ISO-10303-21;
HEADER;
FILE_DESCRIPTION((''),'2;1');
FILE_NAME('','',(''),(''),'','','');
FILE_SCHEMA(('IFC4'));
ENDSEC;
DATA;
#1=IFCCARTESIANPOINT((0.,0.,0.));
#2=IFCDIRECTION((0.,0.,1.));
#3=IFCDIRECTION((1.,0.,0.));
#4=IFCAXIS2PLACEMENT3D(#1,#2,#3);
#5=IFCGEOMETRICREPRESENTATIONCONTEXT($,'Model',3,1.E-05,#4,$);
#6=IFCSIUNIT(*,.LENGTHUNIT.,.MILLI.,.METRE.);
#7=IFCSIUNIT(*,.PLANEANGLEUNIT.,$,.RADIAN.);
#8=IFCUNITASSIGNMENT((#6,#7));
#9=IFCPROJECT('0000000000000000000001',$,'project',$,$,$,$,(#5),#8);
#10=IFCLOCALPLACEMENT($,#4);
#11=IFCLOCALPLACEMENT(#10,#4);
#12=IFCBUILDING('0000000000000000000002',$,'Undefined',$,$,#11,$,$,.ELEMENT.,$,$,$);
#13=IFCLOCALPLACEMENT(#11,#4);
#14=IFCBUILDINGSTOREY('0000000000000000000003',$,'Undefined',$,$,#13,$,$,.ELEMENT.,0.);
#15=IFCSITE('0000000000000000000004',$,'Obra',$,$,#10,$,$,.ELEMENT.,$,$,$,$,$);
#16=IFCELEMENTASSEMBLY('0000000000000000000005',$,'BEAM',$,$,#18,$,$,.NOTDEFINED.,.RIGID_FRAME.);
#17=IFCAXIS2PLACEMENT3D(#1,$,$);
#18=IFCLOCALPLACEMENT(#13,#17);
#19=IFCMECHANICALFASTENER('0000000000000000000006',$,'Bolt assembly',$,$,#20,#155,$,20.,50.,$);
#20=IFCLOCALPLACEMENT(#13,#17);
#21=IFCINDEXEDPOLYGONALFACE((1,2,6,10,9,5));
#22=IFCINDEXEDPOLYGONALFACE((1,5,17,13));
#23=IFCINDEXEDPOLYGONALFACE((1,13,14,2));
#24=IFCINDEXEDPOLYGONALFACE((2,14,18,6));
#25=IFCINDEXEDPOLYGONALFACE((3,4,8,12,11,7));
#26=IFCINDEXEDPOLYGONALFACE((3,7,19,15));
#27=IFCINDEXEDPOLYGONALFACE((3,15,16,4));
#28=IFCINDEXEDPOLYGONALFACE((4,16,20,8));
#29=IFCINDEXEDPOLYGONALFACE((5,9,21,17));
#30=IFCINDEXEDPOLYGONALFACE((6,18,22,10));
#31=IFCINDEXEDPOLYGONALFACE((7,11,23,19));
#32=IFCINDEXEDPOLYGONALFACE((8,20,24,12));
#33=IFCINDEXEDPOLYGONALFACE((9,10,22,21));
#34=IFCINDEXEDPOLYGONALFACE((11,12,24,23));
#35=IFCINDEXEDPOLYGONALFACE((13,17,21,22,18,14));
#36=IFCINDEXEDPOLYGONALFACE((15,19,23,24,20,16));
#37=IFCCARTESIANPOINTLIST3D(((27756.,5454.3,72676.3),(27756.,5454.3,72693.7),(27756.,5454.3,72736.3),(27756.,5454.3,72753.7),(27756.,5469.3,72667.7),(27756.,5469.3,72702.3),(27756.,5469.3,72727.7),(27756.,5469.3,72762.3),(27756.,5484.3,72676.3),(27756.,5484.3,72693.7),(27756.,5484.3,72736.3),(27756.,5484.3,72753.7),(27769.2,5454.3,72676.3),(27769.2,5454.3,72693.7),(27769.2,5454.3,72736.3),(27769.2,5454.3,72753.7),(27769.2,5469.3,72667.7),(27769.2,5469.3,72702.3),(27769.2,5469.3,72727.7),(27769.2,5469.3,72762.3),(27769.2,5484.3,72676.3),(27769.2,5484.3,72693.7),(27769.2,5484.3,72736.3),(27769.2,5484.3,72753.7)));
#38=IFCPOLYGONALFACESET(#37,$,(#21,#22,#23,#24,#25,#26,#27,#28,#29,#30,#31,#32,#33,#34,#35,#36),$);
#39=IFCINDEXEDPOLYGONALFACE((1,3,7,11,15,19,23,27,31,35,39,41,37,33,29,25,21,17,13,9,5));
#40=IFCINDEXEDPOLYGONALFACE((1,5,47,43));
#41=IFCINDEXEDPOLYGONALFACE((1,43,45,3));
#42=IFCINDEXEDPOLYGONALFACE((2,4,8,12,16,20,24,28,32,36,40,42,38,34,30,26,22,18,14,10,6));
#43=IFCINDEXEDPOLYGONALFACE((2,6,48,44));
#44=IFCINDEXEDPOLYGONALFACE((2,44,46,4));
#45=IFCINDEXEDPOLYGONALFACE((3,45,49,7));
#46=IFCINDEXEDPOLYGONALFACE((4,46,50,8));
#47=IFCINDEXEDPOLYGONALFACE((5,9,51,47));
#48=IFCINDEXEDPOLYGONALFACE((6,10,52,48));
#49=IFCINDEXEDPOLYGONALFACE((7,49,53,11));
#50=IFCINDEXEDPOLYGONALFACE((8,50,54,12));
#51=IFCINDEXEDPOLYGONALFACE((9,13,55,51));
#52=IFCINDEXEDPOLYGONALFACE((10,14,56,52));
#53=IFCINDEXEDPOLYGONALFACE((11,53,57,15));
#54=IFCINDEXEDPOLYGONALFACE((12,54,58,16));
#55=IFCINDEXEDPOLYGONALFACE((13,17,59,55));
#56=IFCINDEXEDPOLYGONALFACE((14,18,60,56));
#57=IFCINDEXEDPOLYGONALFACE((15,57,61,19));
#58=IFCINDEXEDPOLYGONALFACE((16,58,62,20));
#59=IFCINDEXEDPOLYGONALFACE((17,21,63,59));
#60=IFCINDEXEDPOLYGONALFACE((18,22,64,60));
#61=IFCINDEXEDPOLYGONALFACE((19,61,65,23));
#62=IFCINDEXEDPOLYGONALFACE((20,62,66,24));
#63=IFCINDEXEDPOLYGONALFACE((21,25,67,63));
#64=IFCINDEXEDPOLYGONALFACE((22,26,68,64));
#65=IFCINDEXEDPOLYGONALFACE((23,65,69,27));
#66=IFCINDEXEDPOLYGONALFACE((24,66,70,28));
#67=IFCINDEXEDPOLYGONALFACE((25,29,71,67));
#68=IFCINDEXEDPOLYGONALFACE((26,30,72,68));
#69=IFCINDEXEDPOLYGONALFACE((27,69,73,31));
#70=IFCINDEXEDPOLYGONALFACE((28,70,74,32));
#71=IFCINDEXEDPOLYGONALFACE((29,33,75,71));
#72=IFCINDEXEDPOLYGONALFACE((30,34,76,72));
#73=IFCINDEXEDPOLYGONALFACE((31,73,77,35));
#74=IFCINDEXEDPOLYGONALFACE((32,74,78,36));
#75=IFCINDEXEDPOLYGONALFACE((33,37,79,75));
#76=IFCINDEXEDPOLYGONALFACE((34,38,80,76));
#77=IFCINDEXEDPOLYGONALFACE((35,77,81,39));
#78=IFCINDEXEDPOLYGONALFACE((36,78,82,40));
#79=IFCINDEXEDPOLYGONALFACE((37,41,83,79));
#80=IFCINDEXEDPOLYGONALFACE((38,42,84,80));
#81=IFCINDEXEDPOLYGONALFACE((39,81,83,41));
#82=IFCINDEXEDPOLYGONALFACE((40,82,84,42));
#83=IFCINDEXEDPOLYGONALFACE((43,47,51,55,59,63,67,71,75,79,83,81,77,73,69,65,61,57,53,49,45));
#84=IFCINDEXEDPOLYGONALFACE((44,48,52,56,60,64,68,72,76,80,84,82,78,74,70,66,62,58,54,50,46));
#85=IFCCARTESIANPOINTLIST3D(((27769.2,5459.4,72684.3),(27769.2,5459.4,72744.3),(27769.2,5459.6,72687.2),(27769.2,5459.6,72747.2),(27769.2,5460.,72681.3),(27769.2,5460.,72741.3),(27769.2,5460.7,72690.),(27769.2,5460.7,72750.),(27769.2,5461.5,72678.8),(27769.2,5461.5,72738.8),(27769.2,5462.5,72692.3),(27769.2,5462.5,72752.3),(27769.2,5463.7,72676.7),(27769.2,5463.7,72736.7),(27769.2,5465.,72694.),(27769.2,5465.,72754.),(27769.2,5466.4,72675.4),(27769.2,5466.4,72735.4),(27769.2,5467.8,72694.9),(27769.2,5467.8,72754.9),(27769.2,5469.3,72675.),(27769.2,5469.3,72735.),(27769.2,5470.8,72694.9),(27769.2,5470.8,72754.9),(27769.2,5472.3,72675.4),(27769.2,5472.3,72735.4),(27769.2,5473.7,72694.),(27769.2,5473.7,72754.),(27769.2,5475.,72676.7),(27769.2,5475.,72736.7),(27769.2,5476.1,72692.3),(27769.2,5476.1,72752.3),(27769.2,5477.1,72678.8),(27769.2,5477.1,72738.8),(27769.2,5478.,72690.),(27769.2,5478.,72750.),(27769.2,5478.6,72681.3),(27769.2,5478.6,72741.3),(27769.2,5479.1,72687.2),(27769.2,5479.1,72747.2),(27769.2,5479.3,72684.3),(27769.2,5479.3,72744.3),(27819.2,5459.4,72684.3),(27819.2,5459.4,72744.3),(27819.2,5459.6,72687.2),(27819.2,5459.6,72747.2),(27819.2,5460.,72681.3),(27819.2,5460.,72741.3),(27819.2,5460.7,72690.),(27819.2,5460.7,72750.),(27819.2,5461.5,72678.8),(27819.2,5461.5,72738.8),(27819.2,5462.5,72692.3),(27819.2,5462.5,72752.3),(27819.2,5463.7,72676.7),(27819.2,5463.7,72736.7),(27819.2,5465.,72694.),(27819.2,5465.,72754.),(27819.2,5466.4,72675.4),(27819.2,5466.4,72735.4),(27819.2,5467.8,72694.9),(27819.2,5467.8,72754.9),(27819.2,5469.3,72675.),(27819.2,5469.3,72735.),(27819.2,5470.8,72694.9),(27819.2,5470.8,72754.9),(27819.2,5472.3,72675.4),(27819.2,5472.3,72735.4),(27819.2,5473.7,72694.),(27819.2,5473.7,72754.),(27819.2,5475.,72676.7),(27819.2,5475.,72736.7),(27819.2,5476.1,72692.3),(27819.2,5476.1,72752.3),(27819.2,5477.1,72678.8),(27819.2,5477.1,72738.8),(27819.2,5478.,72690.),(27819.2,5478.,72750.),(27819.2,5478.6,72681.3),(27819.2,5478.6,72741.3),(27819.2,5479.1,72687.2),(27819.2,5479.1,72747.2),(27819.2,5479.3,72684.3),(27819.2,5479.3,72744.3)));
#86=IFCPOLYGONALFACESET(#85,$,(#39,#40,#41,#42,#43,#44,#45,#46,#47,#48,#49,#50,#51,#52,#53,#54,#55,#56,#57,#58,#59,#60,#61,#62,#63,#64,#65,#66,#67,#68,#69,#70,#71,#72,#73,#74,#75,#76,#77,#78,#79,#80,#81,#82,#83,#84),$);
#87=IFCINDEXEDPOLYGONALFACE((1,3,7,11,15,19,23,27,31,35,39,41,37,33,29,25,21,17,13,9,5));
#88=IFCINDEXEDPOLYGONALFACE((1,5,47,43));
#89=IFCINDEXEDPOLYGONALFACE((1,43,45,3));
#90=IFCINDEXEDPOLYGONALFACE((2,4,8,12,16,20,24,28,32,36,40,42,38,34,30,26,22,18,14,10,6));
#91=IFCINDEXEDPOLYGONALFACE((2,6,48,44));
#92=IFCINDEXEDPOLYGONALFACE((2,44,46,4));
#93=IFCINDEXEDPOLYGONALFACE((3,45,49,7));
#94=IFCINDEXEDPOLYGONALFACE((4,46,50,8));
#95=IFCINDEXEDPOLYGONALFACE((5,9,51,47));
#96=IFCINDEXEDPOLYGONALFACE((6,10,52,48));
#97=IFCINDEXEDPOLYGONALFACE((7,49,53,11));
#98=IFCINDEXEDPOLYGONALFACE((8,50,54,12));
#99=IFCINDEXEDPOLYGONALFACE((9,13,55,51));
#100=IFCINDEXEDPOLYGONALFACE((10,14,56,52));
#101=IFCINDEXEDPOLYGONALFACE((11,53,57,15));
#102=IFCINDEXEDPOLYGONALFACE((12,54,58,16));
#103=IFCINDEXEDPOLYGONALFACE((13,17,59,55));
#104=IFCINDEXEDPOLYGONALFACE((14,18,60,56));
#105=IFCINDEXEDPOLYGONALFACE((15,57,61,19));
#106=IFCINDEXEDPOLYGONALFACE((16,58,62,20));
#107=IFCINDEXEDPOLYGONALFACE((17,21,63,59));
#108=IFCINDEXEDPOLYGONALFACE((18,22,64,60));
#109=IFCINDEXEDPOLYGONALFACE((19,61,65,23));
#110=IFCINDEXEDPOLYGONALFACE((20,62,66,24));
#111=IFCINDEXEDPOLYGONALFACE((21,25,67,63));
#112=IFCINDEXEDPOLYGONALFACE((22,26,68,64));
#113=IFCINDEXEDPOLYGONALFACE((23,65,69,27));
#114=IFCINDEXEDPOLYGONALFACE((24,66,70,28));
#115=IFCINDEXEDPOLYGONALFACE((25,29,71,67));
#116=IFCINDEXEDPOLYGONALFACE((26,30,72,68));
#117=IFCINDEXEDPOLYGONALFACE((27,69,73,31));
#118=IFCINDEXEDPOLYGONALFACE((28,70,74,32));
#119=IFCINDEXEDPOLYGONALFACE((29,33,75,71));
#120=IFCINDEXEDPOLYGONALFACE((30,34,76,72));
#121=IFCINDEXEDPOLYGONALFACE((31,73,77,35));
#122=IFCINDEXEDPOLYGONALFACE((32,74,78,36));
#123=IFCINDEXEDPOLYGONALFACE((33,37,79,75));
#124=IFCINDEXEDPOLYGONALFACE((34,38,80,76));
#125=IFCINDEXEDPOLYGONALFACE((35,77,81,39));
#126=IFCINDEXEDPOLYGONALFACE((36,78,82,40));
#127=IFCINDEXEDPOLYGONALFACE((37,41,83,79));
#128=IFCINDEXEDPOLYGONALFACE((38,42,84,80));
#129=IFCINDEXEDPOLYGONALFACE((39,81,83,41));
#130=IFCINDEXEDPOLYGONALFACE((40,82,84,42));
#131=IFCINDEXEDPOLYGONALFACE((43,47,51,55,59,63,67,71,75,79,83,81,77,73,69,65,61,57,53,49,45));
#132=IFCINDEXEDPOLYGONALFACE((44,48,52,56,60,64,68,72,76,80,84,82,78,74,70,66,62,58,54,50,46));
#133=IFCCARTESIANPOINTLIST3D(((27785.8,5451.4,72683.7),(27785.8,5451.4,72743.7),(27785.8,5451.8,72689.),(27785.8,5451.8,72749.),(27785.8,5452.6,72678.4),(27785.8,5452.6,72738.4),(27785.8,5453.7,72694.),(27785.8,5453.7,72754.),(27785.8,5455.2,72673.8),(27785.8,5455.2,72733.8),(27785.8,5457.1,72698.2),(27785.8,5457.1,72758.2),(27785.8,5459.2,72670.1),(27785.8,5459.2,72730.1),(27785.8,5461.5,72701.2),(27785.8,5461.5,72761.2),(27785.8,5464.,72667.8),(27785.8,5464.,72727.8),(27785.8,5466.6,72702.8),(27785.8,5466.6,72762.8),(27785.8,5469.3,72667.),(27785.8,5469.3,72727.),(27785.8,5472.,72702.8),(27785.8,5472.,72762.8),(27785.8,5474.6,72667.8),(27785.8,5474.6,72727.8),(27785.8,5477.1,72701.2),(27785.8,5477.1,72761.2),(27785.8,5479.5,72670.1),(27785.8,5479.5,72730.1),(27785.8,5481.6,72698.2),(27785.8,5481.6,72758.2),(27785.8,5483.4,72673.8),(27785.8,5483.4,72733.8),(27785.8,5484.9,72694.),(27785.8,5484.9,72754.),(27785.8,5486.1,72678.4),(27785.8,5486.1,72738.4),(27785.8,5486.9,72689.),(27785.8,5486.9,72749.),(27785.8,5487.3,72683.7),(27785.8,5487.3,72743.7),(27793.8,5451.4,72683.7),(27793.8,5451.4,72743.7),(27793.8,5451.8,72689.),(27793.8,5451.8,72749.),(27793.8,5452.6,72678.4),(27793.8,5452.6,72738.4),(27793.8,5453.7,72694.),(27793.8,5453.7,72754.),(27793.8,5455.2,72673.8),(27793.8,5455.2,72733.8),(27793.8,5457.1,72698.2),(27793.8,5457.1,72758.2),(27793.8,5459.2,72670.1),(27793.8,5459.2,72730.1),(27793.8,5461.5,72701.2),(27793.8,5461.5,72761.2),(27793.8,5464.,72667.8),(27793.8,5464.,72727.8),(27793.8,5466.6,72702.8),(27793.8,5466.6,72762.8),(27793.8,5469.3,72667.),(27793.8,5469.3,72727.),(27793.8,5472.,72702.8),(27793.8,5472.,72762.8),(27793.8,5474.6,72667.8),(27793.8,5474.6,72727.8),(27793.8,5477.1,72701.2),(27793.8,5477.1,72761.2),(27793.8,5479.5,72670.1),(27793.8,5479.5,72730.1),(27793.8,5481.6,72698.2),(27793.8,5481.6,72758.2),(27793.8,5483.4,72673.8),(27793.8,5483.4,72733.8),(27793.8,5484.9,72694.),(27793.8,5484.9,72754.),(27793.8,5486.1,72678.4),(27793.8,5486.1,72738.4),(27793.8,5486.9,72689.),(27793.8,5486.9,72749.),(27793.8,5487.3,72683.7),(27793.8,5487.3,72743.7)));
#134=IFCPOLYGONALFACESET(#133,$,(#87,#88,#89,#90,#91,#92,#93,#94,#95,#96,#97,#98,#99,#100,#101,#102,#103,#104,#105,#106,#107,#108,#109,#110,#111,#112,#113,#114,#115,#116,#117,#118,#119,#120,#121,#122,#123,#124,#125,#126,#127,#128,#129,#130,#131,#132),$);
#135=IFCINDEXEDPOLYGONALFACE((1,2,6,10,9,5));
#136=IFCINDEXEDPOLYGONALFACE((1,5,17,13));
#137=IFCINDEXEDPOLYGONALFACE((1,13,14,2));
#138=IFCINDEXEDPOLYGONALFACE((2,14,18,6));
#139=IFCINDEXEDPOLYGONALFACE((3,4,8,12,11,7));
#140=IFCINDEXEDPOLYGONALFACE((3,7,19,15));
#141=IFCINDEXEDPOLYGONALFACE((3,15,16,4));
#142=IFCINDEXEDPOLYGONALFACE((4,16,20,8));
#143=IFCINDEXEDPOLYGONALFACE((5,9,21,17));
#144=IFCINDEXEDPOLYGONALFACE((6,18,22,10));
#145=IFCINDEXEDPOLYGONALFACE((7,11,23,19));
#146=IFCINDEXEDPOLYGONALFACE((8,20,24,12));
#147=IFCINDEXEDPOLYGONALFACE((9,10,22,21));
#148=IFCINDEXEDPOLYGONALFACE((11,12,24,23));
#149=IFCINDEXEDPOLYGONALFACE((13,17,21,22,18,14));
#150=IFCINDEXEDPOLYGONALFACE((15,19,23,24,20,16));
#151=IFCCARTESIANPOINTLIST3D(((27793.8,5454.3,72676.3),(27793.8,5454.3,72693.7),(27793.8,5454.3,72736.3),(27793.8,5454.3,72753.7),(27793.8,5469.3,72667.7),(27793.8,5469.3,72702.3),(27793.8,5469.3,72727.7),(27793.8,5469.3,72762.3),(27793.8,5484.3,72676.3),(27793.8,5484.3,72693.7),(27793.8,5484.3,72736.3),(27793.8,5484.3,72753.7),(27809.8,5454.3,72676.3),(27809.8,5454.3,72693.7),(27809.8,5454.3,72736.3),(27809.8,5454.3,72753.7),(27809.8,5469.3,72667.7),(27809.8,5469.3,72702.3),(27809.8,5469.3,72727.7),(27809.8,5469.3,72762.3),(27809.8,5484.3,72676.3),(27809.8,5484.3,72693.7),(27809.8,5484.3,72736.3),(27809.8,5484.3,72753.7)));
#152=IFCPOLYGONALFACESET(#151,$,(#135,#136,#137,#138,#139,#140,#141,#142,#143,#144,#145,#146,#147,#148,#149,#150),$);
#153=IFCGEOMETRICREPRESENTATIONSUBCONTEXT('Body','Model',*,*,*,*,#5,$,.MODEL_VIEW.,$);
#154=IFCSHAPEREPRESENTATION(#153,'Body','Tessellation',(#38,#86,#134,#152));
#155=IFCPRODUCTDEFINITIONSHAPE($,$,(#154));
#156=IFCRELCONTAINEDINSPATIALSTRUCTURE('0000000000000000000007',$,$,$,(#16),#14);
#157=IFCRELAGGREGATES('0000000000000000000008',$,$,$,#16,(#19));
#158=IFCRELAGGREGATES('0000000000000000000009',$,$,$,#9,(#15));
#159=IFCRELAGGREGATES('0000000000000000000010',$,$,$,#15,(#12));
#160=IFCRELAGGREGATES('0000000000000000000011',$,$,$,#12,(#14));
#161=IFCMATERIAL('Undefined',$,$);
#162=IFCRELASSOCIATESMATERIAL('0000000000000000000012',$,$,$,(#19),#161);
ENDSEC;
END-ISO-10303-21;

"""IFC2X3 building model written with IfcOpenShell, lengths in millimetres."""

from ifc_helpers import new_model, si_unit, frame, origin_with_axes, origin_2d_with_axis, place, context, subcontext, project, spatial, polyline, circle, outline, extrude, source, transform, mapped, material, element, aggregate, save


model = new_model("IFC2X3")

# Units and contexts
model_context = context("Model", 3, precision=1e-05, world=origin_with_axes())
body_context = subcontext(model_context, "Body", "Model", "MODEL_VIEW")
ifc_project = project(units=[si_unit("LENGTHUNIT", "METRE", prefix="MILLI"), si_unit("PLANEANGLEUNIT", "RADIAN")], contexts=[model_context])

# Site, building, storey
site_placement = place(None, origin_with_axes())
site = spatial("IfcSite", under=ifc_project, at=site_placement, Name="Obra", CompositionType="ELEMENT")
building_placement = place(site_placement, origin_with_axes())
building = spatial("IfcBuilding", under=site, at=building_placement, Name="Undefined", CompositionType="ELEMENT")
storey_placement = place(building_placement, origin_with_axes())
storey = spatial("IfcBuildingStorey", under=building, at=storey_placement, Name="Undefined", CompositionType="ELEMENT", Elevation=0.0)

# Shared definitions
ifc_material = material(Name="Undefined")

# Element assembly, mechanical fastener
assembly_1_placement = place(storey_placement, origin_with_axes())
assembly_1 = element("IfcElementAssembly", 1, at=assembly_1_placement, inside=storey, Name="BEAM", AssemblyPlace="NOTDEFINED", PredefinedType="RIGID_FRAME")
shared_shape_1 = source(origin_with_axes(), body_context, "Body", "SweptSolid", [
    extrude(outline(polyline([(17.3, 0.0), (8.7, 15.0), (-8.7, 15.0), (-17.3, 0.0), (-8.7, -15.0), (8.7, -15.0), (17.3, 0.0)])), frame((0.0, -26.5, 0.0), z_axis=(0.0, 1.0, 0.0), x_axis=(1.0, 0.0, 0.0)), (0.0, 0.0, 1.0), 13.2),
    extrude(circle(Radius=10.0, at=origin_2d_with_axis()), frame((0.0, -13.3, 0.0), z_axis=(0.0, 1.0, 0.0), x_axis=(1.0, 0.0, 0.0)), (0.0, 0.0, 1.0), 50.0),
    extrude(circle(Radius=18.0, at=origin_2d_with_axis()), frame((0.0, 3.3, 0.0), z_axis=(0.0, 1.0, 0.0), x_axis=(1.0, 0.0, 0.0)), (0.0, 0.0, 1.0), 8.0),
    extrude(outline(polyline([(17.3, 0.0), (8.7, 15.0), (-8.7, 15.0), (-17.3, 0.0), (-8.7, -15.0), (8.7, -15.0), (17.3, 0.0)])), frame((0.0, 11.3, 0.0), z_axis=(0.0, 1.0, 0.0), x_axis=(1.0, 0.0, 0.0)), (0.0, 0.0, 1.0), 16.0),
])
mechanical_fastener_1_placement = place(assembly_1_placement, frame((27782.5, 5509.3, 72850.0), z_axis=(0.000002, -1.0, 0.0), x_axis=(0.0, 0.0, -1.0)))
mechanical_fastener_1 = element("IfcMechanicalFastener", 2, at=mechanical_fastener_1_placement, material=ifc_material, Name="Bolt assembly", NominalDiameter=20.0, NominalLength=50.0, context=body_context, shape_type="MappedRepresentation", body=[
    mapped(shared_shape_1, transform((105.0, 0.0, 40.0))),
    mapped(shared_shape_1, transform((165.0, 0.0, 40.0))),
])
aggregate(assembly_1, [mechanical_fastener_1])

save(model, "model.ifc")
